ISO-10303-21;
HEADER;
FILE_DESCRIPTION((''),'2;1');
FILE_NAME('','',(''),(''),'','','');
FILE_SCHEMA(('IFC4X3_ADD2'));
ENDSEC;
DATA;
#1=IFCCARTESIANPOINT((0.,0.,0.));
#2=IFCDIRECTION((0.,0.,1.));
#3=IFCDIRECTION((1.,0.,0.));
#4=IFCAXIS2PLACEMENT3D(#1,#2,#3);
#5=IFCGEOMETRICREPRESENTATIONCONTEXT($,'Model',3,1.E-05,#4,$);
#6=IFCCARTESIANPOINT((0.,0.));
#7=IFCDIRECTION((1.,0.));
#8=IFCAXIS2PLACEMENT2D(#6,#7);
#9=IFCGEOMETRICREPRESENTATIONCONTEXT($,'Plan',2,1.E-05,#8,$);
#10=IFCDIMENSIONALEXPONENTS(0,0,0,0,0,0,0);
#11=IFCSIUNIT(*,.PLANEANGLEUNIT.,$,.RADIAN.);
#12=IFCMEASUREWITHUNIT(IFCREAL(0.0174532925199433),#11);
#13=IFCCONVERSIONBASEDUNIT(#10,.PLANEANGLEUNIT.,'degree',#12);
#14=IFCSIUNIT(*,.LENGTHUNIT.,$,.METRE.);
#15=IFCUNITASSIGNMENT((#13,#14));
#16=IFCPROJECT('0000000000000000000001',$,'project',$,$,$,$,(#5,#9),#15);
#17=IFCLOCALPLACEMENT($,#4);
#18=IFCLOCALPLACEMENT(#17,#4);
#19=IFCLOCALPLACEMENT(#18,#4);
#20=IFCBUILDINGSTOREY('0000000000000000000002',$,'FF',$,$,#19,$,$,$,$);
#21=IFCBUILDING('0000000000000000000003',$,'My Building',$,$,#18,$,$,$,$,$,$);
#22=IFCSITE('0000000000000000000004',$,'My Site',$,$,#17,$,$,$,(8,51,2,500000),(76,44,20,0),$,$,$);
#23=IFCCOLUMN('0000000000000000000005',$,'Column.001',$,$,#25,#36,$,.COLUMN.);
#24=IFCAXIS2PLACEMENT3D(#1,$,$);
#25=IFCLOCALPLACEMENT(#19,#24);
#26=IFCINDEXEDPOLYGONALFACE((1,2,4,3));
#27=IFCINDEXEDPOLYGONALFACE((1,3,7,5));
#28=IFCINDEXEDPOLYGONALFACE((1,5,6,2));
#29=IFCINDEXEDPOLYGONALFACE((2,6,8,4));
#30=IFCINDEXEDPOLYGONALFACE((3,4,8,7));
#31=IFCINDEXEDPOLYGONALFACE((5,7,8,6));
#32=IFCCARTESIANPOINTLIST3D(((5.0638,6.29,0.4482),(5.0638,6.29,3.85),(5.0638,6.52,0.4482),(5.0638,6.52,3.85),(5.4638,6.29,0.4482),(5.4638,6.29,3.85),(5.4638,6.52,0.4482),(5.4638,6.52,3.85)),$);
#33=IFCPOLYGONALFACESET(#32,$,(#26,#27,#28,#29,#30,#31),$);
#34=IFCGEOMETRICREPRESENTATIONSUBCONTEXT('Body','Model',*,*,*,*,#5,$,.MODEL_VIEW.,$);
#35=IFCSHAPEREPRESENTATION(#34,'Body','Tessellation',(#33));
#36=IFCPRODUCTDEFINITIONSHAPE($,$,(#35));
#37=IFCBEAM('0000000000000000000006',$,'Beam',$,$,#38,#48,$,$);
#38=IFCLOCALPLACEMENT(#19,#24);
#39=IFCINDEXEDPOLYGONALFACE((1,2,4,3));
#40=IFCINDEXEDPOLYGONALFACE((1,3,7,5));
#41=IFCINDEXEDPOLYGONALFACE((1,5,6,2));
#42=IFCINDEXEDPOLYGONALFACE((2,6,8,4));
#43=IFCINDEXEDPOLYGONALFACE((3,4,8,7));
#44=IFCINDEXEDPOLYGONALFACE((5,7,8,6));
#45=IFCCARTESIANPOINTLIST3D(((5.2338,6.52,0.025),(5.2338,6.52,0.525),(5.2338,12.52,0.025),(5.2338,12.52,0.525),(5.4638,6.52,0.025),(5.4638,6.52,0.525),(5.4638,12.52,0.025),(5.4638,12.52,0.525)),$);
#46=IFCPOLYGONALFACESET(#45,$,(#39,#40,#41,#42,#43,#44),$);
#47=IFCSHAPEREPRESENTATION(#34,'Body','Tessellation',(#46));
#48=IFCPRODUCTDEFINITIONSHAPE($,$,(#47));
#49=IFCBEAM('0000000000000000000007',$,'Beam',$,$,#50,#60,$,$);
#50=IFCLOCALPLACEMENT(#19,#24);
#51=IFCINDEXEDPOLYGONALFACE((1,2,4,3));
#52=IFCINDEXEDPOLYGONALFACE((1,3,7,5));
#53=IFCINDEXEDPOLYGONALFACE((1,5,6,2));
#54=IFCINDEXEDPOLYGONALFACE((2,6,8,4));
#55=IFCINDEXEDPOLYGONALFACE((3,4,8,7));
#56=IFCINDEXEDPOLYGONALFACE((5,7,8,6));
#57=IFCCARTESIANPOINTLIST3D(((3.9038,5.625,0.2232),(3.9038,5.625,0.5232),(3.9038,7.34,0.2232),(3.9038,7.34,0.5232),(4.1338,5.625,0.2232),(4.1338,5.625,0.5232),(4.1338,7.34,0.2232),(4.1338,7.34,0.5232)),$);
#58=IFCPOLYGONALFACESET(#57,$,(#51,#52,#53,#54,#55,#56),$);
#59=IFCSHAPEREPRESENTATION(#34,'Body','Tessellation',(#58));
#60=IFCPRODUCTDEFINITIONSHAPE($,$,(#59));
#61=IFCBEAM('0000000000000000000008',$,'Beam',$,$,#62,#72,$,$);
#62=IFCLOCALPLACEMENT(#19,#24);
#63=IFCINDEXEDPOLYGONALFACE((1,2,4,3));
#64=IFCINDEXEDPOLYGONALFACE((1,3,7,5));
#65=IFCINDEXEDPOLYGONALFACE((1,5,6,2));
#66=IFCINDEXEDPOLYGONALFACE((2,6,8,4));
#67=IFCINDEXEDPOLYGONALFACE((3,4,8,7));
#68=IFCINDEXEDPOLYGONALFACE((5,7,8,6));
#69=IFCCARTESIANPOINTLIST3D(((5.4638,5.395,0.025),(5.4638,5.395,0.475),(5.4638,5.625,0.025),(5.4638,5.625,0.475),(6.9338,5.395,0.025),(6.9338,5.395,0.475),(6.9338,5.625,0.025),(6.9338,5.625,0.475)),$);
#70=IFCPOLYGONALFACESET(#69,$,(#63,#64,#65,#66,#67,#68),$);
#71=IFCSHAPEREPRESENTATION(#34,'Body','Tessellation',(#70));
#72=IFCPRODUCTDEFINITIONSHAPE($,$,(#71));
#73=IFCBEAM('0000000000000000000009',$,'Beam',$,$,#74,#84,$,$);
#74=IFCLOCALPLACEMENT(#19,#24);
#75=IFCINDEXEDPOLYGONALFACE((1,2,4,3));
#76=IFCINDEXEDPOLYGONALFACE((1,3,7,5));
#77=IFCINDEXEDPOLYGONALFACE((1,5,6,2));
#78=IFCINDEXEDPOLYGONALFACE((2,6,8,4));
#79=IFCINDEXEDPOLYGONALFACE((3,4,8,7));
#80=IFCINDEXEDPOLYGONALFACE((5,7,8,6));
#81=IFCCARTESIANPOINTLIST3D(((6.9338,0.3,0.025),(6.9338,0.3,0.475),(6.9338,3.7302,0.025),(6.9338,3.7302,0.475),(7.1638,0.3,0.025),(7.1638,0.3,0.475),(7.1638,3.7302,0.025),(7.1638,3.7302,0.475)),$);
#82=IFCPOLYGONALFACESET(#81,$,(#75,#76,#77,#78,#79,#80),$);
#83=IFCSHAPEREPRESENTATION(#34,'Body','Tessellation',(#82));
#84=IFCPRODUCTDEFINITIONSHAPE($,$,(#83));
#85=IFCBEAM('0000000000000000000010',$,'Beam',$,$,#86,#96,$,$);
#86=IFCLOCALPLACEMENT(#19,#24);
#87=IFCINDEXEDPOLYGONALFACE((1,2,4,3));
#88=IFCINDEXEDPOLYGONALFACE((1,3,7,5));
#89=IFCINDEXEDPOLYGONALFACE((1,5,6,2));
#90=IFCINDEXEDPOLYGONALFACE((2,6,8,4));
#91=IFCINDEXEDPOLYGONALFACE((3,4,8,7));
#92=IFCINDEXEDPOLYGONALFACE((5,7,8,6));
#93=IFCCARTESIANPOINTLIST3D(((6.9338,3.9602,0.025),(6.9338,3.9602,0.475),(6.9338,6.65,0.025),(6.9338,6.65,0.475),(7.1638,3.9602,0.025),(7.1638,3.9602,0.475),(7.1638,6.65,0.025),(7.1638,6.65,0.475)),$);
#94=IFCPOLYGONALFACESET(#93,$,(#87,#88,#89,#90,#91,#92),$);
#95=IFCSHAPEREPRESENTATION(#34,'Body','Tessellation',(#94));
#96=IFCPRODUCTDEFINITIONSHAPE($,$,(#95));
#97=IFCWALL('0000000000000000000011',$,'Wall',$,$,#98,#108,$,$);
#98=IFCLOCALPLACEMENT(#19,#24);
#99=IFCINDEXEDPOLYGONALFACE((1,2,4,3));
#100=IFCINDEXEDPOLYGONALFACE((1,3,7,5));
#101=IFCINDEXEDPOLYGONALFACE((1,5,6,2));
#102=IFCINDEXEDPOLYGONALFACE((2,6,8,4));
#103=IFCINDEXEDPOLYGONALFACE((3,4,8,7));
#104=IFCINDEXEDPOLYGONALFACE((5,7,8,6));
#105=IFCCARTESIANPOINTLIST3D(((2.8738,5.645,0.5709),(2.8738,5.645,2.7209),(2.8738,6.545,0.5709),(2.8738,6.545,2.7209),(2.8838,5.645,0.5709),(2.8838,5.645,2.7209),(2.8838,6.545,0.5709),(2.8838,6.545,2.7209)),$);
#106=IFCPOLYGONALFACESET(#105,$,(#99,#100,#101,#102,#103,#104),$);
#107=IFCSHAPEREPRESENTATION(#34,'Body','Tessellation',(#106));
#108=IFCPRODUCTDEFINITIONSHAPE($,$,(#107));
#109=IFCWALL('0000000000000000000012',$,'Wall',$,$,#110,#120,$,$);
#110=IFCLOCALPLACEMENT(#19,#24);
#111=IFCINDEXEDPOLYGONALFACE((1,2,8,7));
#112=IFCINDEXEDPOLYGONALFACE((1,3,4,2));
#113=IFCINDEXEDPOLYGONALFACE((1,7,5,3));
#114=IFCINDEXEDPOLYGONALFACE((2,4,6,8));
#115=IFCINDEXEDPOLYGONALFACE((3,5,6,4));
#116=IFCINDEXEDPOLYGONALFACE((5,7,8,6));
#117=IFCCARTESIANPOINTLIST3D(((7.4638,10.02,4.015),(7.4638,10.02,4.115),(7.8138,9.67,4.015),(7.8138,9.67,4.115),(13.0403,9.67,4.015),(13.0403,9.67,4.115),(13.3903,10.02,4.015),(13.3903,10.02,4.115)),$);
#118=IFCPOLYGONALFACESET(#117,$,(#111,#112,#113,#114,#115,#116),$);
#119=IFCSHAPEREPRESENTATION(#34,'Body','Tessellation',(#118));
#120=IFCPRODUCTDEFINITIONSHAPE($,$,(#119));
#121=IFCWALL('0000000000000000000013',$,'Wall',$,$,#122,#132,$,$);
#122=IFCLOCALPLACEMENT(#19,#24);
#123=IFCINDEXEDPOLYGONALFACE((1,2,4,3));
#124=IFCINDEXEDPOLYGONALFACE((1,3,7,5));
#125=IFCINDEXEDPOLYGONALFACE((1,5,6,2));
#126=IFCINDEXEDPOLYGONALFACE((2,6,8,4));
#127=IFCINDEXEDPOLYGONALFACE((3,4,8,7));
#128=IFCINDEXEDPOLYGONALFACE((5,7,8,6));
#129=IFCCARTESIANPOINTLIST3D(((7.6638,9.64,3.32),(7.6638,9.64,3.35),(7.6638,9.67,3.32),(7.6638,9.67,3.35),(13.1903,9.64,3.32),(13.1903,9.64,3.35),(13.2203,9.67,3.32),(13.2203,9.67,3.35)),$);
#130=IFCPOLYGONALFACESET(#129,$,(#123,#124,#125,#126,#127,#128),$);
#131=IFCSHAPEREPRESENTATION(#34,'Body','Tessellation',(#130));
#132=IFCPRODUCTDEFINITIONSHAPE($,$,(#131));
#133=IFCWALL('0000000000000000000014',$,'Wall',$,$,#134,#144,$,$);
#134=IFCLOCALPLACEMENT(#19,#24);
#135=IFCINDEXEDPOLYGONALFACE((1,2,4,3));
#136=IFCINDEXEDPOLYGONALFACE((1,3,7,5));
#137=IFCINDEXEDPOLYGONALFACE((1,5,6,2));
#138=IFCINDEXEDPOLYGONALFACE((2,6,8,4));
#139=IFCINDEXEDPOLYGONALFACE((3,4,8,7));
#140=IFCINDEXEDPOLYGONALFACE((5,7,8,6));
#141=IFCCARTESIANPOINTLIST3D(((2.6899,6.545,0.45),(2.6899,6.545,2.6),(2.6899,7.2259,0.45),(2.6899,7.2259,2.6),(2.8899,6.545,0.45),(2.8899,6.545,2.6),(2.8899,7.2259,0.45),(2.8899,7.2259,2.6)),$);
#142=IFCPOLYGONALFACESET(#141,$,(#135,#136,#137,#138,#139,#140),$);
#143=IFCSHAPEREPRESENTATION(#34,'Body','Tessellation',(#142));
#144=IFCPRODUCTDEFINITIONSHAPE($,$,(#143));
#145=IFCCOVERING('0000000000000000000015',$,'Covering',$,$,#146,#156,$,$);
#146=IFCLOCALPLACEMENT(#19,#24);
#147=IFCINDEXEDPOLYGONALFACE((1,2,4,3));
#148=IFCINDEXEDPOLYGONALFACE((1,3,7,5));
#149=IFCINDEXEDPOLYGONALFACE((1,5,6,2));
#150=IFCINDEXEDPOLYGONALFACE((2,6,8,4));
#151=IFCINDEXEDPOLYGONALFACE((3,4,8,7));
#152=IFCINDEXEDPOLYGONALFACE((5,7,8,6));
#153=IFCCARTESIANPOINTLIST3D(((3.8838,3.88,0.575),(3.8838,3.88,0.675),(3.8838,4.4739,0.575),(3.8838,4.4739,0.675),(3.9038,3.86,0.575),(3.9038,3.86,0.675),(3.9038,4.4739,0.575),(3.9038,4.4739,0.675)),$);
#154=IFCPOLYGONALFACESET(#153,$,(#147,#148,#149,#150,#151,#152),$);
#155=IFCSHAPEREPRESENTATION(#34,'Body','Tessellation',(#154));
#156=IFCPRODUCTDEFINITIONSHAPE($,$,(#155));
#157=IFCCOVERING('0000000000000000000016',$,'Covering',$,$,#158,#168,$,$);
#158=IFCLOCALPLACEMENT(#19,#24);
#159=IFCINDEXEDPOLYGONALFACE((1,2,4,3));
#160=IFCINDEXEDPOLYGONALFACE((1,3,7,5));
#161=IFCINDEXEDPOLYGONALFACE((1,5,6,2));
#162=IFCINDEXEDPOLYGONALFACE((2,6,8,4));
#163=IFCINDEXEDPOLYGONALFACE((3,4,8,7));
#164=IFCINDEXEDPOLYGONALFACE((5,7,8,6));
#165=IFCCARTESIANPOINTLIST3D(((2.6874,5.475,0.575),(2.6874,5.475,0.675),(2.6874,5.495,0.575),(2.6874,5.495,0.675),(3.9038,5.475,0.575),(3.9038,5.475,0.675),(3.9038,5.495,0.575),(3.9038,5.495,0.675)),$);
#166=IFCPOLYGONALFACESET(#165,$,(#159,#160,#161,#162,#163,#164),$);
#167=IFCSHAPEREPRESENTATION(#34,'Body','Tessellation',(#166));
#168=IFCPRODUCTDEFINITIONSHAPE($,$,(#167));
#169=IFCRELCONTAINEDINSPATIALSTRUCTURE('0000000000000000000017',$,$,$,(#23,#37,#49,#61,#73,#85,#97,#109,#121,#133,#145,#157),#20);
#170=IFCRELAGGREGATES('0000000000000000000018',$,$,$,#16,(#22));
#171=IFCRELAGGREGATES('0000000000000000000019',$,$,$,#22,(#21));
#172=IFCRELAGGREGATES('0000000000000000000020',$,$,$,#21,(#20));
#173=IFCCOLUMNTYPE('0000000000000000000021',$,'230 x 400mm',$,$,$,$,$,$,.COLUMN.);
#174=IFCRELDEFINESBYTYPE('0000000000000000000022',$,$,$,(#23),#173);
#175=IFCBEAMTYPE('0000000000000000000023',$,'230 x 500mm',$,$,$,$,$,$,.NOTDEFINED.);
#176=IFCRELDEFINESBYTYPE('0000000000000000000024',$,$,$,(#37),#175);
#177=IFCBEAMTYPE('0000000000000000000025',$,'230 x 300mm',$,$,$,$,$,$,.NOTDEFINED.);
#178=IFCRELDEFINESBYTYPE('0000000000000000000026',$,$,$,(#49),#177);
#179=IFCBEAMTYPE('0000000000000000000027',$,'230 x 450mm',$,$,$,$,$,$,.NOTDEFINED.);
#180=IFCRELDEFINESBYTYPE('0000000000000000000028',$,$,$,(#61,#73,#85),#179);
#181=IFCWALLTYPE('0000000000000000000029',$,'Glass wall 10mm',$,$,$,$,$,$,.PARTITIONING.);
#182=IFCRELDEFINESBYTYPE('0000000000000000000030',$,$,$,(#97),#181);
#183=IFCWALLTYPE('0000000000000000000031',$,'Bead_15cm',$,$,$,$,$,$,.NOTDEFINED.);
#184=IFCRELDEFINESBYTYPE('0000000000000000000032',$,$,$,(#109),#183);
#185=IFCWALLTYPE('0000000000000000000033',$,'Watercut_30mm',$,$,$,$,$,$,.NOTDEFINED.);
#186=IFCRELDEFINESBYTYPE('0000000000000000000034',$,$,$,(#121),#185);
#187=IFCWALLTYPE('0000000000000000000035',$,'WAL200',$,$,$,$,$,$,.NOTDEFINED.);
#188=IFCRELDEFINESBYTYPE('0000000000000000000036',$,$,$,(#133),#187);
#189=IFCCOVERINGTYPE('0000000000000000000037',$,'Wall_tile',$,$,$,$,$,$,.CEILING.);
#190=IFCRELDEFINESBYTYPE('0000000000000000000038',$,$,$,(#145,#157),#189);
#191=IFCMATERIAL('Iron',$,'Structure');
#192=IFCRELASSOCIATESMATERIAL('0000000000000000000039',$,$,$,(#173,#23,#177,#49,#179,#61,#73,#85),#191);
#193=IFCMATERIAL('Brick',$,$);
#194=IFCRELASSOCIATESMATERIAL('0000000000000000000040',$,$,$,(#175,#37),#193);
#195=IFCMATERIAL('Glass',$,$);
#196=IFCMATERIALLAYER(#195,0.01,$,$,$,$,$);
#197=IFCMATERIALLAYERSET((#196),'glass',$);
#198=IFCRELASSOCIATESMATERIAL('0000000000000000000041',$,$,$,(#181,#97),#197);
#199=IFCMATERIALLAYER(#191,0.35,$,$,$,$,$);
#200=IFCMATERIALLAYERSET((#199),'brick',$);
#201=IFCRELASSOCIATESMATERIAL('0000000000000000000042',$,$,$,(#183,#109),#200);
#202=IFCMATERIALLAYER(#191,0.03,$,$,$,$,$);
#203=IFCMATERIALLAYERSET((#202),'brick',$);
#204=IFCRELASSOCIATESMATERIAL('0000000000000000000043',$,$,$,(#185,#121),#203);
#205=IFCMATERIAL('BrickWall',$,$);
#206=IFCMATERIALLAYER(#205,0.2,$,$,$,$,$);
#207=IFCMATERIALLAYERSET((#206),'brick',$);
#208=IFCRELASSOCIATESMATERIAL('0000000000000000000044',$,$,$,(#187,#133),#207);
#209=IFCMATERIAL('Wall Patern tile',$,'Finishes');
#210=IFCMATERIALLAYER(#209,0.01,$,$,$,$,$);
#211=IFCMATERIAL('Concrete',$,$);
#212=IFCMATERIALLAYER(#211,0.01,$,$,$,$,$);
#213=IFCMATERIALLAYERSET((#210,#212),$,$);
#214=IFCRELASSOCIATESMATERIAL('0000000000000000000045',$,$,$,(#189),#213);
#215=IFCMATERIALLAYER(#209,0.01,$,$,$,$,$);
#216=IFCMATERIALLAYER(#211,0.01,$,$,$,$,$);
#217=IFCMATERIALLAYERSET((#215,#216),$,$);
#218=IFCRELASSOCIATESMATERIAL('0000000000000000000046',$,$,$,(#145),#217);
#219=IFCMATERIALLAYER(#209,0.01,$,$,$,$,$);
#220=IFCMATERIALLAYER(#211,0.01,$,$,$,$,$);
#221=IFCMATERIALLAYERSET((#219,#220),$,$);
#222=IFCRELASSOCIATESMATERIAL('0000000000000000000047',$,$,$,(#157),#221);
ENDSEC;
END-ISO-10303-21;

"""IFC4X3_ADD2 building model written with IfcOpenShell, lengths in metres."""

from ifc_helpers import new_model, entity, si_unit, converted_unit, frame, origin_with_axes, origin_2d_with_axis, place, context, subcontext, project, spatial, line, indexed_curve, rectangle, outline, extrude, material, layer, layer_set, layer_usage, material_profile, profile_set, profile_usage, type_object, element, save


model = new_model("IFC4X3_ADD2")

# Units and contexts
model_context = context("Model", 3, precision=1e-05, world=origin_with_axes())
plan_context = context("Plan", 2, precision=1e-05, world=origin_2d_with_axis())
body_context_1 = subcontext(model_context, "Body", "Model", "MODEL_VIEW")
ifc_project = project(units=[converted_unit("PLANEANGLEUNIT", "degree", entity("IfcReal", 0.0174532925199433), si_unit("PLANEANGLEUNIT", "RADIAN"), dimensions=[0, 0, 0, 0, 0, 0, 0]), si_unit("LENGTHUNIT", "METRE")], contexts=[model_context, plan_context])

# Site, building, storey
site_placement = place(None, origin_with_axes())
site = spatial("IfcSite", under=ifc_project, at=site_placement, Name="My Site", RefLatitude=(8, 51, 2, 500000), RefLongitude=(76, 44, 20, 0))
building_placement = place(site_placement, origin_with_axes())
building = spatial("IfcBuilding", under=site, at=building_placement, Name="My Building")
storey_placement = place(building_placement, origin_with_axes())
storey = spatial("IfcBuildingStorey", under=building, at=storey_placement, Name="FF")

# Column
ifc_material_1 = material(Name="Iron", Category="Structure")
ifc_material_profile_1 = material_profile(ifc_material_1, outline(indexed_curve([(-0.115, 0.2), (0.115, 0.2), (0.115, -0.2), (-0.115, -0.2), (-0.115, 0.2)])))
ifc_profile_set_1 = profile_set([ifc_material_profile_1])
ifc_profile_usage_1 = profile_usage(ifc_profile_set_1)
column_type = type_object("IfcColumnType", Name="230 x 400mm", PredefinedType="COLUMN", material=ifc_profile_set_1)
column_placement = place(storey_placement, frame((5.2638, 6.405, 0.4482), z_axis=(0.0, 0.0, 1.0), x_axis=(0.0, 1.0, 0.0)))
element("IfcColumn", 1, at=column_placement, inside=storey, type_object=column_type, material=ifc_profile_usage_1, Name="Column.001", PredefinedType="COLUMN", context=body_context_1, shape_type="SweptSolid", body=[
    extrude(outline(indexed_curve([(-0.115, 0.2), (0.115, 0.2), (0.115, -0.2), (-0.115, -0.2), (-0.115, 0.2)])), origin_with_axes(), (0.0, 0.0, 1.0), 3.4018),
])

# Beams
ifc_material_2 = material(Name="Brick")
ifc_material_profile_2 = material_profile(ifc_material_2, rectangle(XDim=0.23, YDim=0.5))
ifc_profile_set_2 = profile_set([ifc_material_profile_2], Name="rcc")
ifc_profile_usage_2 = profile_usage(ifc_profile_set_2)
beam_type_1 = type_object("IfcBeamType", Name="230 x 500mm", PredefinedType="NOTDEFINED", material=ifc_profile_set_2)
beam_1_placement = place(storey_placement, frame((5.3488, 6.52, 0.275), z_axis=(0.0, 1.0, 0.0), x_axis=(-1.0, 0.0, 0.0)))
element("IfcBeam", 2, at=beam_1_placement, inside=storey, type_object=beam_type_1, material=ifc_profile_usage_2, Name="Beam", context=body_context_1, shape_type="SweptSolid", body=[
    extrude(rectangle(XDim=0.23, YDim=0.5), origin_with_axes(), (0.0, 0.0, 1.0), 6.0),
])
ifc_material_profile_3 = material_profile(ifc_material_1, rectangle(XDim=0.23, YDim=0.3))
ifc_profile_set_3 = profile_set([ifc_material_profile_3], Name="blank")
ifc_profile_usage_3 = profile_usage(ifc_profile_set_3)
beam_type_2 = type_object("IfcBeamType", Name="230 x 300mm", PredefinedType="NOTDEFINED", material=ifc_profile_set_3)
beam_2_placement = place(storey_placement, frame((4.0188, 5.625, 0.3732), z_axis=(0.0, 1.0, 0.0), x_axis=(-1.0, 0.0, 0.0)))
element("IfcBeam", 3, at=beam_2_placement, inside=storey, type_object=beam_type_2, material=ifc_profile_usage_3, Name="Beam", context=body_context_1, shape_type="SweptSolid", body=[
    extrude(rectangle(XDim=0.23, YDim=0.3), origin_with_axes(), (0.0, 0.0, 1.0), 1.715),
])
ifc_material_profile_4 = material_profile(ifc_material_1, rectangle(XDim=0.23, YDim=0.45))
ifc_profile_set_4 = profile_set([ifc_material_profile_4], Name="blank")
ifc_profile_usage_4 = profile_usage(ifc_profile_set_4)
beam_type_3 = type_object("IfcBeamType", Name="230 x 450mm", PredefinedType="NOTDEFINED", material=ifc_profile_set_4)
beam_3_placement = place(storey_placement, frame((5.4638, 5.51, 0.25), z_axis=(1.0, 0.0, 0.0), x_axis=(0.0, 1.0, 0.0)))
element("IfcBeam", 4, at=beam_3_placement, inside=storey, type_object=beam_type_3, material=ifc_profile_usage_4, Name="Beam", context=body_context_1, shape_type="SweptSolid", body=[
    extrude(rectangle(XDim=0.23, YDim=0.45), origin_with_axes(), (0.0, 0.0, 1.0), 1.47),
])
ifc_profile_usage_5 = profile_usage(ifc_profile_set_4)
beam_4_placement = place(storey_placement, frame((7.0488, 3.7302, 0.25), z_axis=(0.0, -1.0, 0.0), x_axis=(1.0, 0.0, 0.0)))
element("IfcBeam", 5, at=beam_4_placement, inside=storey, type_object=beam_type_3, material=ifc_profile_usage_5, Name="Beam", context=body_context_1, shape_type="SweptSolid", body=[
    extrude(rectangle(XDim=0.23, YDim=0.45), origin_with_axes(), (0.0, 0.0, 1.0), 3.4302),
])
ifc_profile_usage_6 = profile_usage(ifc_profile_set_4)
beam_5_placement = place(storey_placement, frame((7.0488, 6.65, 0.25), z_axis=(0.0, -1.0, 0.0), x_axis=(1.0, 0.0, 0.0)))
element("IfcBeam", 6, at=beam_5_placement, inside=storey, type_object=beam_type_3, material=ifc_profile_usage_6, Name="Beam", context=body_context_1, shape_type="SweptSolid", body=[
    extrude(rectangle(XDim=0.23, YDim=0.45), origin_with_axes(), (0.0, 0.0, 1.0), 2.6898),
])

# Shared definitions
ifc_material_3 = material(Name="BrickWall")

# Walls
ifc_material_4 = material(Name="Glass")
ifc_layer_1 = layer(ifc_material_4, 0.01)
ifc_layer_set_1 = layer_set([ifc_layer_1], Name="glass")
ifc_layer_usage_1 = layer_usage(ifc_layer_set_1, "AXIS2", "POSITIVE", 0.0)
wall_type_1 = type_object("IfcWallType", Name="Glass wall 10mm", PredefinedType="PARTITIONING", material=ifc_layer_set_1)
wall_1_placement = place(storey_placement, frame((2.8838, 5.645, 0.5709), z_axis=(0.0, 0.0, 1.0), x_axis=(0.0, 1.0, 0.0)))
element("IfcWall", 7, at=wall_1_placement, inside=storey, type_object=wall_type_1, material=ifc_layer_usage_1, Name="Wall", context=body_context_1, shape_type="SweptSolid", body=[
    extrude(outline(indexed_curve([(0.0, 0.0), (0.0, 0.01), (0.9, 0.01), (0.9, 0.0)], segments=[line(1, 2, 3, 4, 1)])), origin_with_axes(), (0.0, 0.0, 1.0), 2.15),
])
ifc_layer_2 = layer(ifc_material_1, 0.35)
ifc_layer_set_2 = layer_set([ifc_layer_2], Name="brick")
ifc_layer_usage_2 = layer_usage(ifc_layer_set_2, "AXIS2", "POSITIVE", 0.0)
wall_type_2 = type_object("IfcWallType", Name="Bead_15cm", PredefinedType="NOTDEFINED", material=ifc_layer_set_2)
wall_2_placement = place(storey_placement, frame((7.8138, 9.67, 4.015), z_axis=(0.0, 0.0, 1.0), x_axis=(1.0, -0.000001, 0.0)))
element("IfcWall", 8, at=wall_2_placement, inside=storey, type_object=wall_type_2, material=ifc_layer_usage_2, Name="Wall", context=body_context_1, shape_type="SweptSolid", body=[
    extrude(outline(indexed_curve([(0.0, 0.0), (-0.35, 0.35), (5.5765, 0.35), (5.2265, 0.0)], segments=[line(1, 2, 3, 4, 1)])), origin_with_axes(), (0.0, 0.0, 1.0), 0.1),
])
ifc_layer_3 = layer(ifc_material_1, 0.03)
ifc_layer_set_3 = layer_set([ifc_layer_3], Name="brick")
ifc_layer_usage_3 = layer_usage(ifc_layer_set_3, "AXIS2", "POSITIVE", 0.0)
wall_type_3 = type_object("IfcWallType", Name="Watercut_30mm", PredefinedType="NOTDEFINED", material=ifc_layer_set_3)
wall_3_placement = place(storey_placement, frame((7.6638, 9.64, 3.32), z_axis=(0.0, 0.0, 1.0), x_axis=(1.0, -0.000001, 0.0)))
element("IfcWall", 9, at=wall_3_placement, inside=storey, type_object=wall_type_3, material=ifc_layer_usage_3, Name="Wall", context=body_context_1, shape_type="SweptSolid", body=[
    extrude(outline(indexed_curve([(0.0, 0.0), (0.0, 0.03), (5.5565, 0.03), (5.5265, 0.0)], segments=[line(1, 2, 3, 4, 1)])), origin_with_axes(), (0.0, 0.0, 1.0), 0.03),
])
ifc_layer_4 = layer(ifc_material_3, 0.2)
ifc_layer_set_4 = layer_set([ifc_layer_4], Name="brick")
ifc_layer_usage_4 = layer_usage(ifc_layer_set_4, "AXIS2", "POSITIVE", 0.0)
wall_type_4 = type_object("IfcWallType", Name="WAL200", PredefinedType="NOTDEFINED", material=ifc_layer_set_4)
wall_4_placement = place(storey_placement, frame((2.8899, 6.545, 0.45), z_axis=(0.0, 0.0, 1.0), x_axis=(0.0, 1.0, 0.0)))
element("IfcWall", 10, at=wall_4_placement, inside=storey, type_object=wall_type_4, material=ifc_layer_usage_4, Name="Wall", context=body_context_1, shape_type="SweptSolid", body=[
    extrude(outline(indexed_curve([(0.0, 0.0), (0.0, 0.2), (0.6809, 0.2), (0.6809, 0.0)], segments=[line(1, 2, 3, 4, 1)])), origin_with_axes(), (0.0, 0.0, 1.0), 2.15),
])

# Coverings
ifc_material_5 = material(Name="Wall Patern tile", Category="Finishes")
ifc_layer_5 = layer(ifc_material_5, 0.01)
ifc_material_6 = material(Name="Concrete")
ifc_layer_6 = layer(ifc_material_6, 0.01)
ifc_layer_set_5 = layer_set([ifc_layer_5, ifc_layer_6])
ifc_layer_usage_5 = layer_usage(ifc_layer_set_5, "AXIS2", "POSITIVE", 0.0)
ifc_layer_7 = layer(ifc_material_5, 0.01)
ifc_layer_8 = layer(ifc_material_6, 0.01)
ifc_layer_set_6 = layer_set([ifc_layer_7, ifc_layer_8])
covering_type_1 = type_object("IfcCoveringType", Name="Wall_tile", PredefinedType="CEILING", material=ifc_layer_set_6)
covering_1_placement = place(storey_placement, frame((3.8838, 4.4739, 0.575), z_axis=(0.0, 0.0, 1.0), x_axis=(0.0, -1.0, 0.0)))
element("IfcCovering", 11, at=covering_1_placement, inside=storey, type_object=covering_type_1, material=ifc_layer_usage_5, Name="Covering", context=body_context_1, shape_type="SweptSolid", body=[
    extrude(outline(indexed_curve([(0.0, 0.0), (0.0, 0.02), (0.6139, 0.02), (0.5939, 0.0)], segments=[line(1, 2, 3, 4, 1)])), origin_with_axes(), (0.0, 0.0, 1.0), 0.1),
])
ifc_layer_9 = layer(ifc_material_5, 0.01)
ifc_layer_10 = layer(ifc_material_6, 0.01)
ifc_layer_set_7 = layer_set([ifc_layer_9, ifc_layer_10])
ifc_layer_usage_6 = layer_usage(ifc_layer_set_7, "AXIS2", "POSITIVE", 0.0)
covering_2_placement = place(storey_placement, frame((2.6874, 5.475, 0.575), z_axis=(0.0, 0.0, 1.0), x_axis=(1.0, 0.0, 0.0)))
element("IfcCovering", 12, at=covering_2_placement, inside=storey, type_object=covering_type_1, material=ifc_layer_usage_6, Name="Covering", context=body_context_1, shape_type="SweptSolid", body=[
    extrude(outline(indexed_curve([(0.0, 0.0), (0.0, 0.02), (1.2164, 0.02), (1.2164, 0.0)], segments=[line(1, 2, 3, 4, 1)])), origin_with_axes(), (0.0, 0.0, 1.0), 0.1),
])

save(model, "model.ifc")
